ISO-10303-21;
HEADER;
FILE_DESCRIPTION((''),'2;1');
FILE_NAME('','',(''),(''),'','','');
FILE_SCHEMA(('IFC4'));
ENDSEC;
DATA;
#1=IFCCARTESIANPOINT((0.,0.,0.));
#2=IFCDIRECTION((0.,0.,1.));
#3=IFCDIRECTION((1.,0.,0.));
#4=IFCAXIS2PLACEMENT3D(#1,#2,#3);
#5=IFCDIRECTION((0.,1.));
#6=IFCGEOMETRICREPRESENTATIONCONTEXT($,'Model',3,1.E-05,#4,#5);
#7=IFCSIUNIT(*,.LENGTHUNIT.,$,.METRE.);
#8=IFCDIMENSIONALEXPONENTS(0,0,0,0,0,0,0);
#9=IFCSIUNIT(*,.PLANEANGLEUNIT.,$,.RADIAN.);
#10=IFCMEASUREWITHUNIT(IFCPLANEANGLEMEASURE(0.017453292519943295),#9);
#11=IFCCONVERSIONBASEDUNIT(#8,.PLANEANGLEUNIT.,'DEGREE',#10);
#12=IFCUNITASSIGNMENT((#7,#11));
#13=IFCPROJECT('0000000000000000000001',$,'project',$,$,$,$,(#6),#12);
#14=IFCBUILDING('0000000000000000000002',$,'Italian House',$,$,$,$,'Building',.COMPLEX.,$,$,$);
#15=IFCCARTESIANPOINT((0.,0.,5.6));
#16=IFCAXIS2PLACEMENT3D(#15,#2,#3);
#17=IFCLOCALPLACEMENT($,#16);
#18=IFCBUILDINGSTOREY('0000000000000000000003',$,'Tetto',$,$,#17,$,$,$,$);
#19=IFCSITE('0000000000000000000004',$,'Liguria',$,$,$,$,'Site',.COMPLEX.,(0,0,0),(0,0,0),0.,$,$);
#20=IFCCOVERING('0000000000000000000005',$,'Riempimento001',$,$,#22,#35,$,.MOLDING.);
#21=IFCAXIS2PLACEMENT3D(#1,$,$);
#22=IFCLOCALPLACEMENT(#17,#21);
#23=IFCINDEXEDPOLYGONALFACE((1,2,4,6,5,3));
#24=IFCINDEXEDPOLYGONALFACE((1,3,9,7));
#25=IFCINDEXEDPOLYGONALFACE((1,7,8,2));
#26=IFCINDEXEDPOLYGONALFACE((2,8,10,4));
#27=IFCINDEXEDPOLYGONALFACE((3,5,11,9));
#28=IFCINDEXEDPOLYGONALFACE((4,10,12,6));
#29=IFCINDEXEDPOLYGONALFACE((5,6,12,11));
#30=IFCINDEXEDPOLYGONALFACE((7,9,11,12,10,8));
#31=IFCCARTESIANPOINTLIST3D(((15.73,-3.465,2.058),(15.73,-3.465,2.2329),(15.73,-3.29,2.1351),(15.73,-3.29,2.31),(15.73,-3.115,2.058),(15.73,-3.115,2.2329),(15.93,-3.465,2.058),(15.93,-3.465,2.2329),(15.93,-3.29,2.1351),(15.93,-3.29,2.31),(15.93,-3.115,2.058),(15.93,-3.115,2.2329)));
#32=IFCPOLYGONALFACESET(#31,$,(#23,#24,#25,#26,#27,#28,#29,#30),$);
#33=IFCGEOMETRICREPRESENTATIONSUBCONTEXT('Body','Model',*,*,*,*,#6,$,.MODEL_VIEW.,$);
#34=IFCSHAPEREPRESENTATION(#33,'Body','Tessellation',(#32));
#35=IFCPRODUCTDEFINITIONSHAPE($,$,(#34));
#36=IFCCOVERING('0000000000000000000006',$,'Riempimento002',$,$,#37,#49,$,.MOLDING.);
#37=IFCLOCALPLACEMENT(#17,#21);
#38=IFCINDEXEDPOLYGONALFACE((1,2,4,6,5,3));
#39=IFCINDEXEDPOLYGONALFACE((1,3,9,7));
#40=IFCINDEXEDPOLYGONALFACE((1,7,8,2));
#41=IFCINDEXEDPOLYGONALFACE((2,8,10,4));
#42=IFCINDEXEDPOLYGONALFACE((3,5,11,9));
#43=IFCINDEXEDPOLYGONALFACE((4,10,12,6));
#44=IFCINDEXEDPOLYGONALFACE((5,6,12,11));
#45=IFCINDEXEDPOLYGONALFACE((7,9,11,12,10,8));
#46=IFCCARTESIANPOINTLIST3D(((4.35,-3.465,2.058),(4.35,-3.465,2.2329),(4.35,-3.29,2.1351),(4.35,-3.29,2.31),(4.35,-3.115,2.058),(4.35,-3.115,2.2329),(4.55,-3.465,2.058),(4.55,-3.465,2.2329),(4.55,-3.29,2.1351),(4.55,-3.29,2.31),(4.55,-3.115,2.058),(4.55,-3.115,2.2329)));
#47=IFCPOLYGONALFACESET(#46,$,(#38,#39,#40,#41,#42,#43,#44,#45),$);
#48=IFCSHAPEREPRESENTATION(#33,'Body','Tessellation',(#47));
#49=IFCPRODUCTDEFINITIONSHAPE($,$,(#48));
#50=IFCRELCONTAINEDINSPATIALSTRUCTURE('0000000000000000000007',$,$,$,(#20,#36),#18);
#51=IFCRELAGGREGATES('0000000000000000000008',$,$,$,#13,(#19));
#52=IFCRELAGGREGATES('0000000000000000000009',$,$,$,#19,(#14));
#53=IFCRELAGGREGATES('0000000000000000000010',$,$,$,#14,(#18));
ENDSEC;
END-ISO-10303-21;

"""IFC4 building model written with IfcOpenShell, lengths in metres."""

from ifc_helpers import new_model, entity, si_unit, converted_unit, direction, frame, origin_with_axes, place, context, subcontext, project, spatial, polyline, outline, extrude, element, save


model = new_model("IFC4")

# Units and contexts
model_context = context("Model", 3, precision=1e-05, world=origin_with_axes(), true_north=direction((0.0, 1.0)))
body_context = subcontext(model_context, "Body", "Model", "MODEL_VIEW")
ifc_project = project(units=[si_unit("LENGTHUNIT", "METRE"), converted_unit("PLANEANGLEUNIT", "DEGREE", entity("IfcPlaneAngleMeasure", 0.017453292519943295), si_unit("PLANEANGLEUNIT", "RADIAN"), dimensions=[0, 0, 0, 0, 0, 0, 0])], contexts=[model_context])

# Site, building, storey
site = spatial("IfcSite", under=ifc_project, Name="Liguria", LongName="Site", CompositionType="COMPLEX", RefLatitude=(0, 0, 0), RefLongitude=(0, 0, 0), RefElevation=0.0)
building = spatial("IfcBuilding", under=site, Name="Italian House", LongName="Building", CompositionType="COMPLEX")
storey_placement = place(None, frame((0.0, 0.0, 5.6), z_axis=(0.0, 0.0, 1.0), x_axis=(1.0, 0.0, 0.0)))
storey = spatial("IfcBuildingStorey", under=building, at=storey_placement, Name="Tetto")

# Coverings
covering_1_placement = place(storey_placement, frame((0.0, 0.0, -5.6), z_axis=(0.0, 0.0, 1.0), x_axis=(1.0, 0.0, 0.0)))
element("IfcCovering", 1, at=covering_1_placement, inside=storey, Name="Riempimento001", PredefinedType="MOLDING", context=body_context, shape_type="SweptSolid", body=[
    extrude(outline(polyline([(-0.126, -0.175), (0.0489, -0.175), (0.126, 0.0), (0.0489, 0.175), (-0.126, 0.175), (-0.0489, 0.0), (-0.126, -0.175)])), frame((15.73, -3.29, 7.784), z_axis=(-1.0, 0.0, 0.0), x_axis=(0.0, 0.0, 1.0)), (0.0, 0.0, -1.0), 0.2),
])
covering_2_placement = place(storey_placement, frame((0.0, 0.0, -5.6), z_axis=(0.0, 0.0, 1.0), x_axis=(1.0, 0.0, 0.0)))
element("IfcCovering", 2, at=covering_2_placement, inside=storey, Name="Riempimento002", PredefinedType="MOLDING", context=body_context, shape_type="SweptSolid", body=[
    extrude(outline(polyline([(-0.126, -0.175), (0.0489, -0.175), (0.126, 0.0), (0.0489, 0.175), (-0.126, 0.175), (-0.0489, 0.0), (-0.126, -0.175)])), frame((4.35, -3.29, 7.784), z_axis=(-1.0, 0.0, 0.0), x_axis=(0.0, 0.0, 1.0)), (0.0, 0.0, -1.0), 0.2),
])

save(model, "model.ifc")
